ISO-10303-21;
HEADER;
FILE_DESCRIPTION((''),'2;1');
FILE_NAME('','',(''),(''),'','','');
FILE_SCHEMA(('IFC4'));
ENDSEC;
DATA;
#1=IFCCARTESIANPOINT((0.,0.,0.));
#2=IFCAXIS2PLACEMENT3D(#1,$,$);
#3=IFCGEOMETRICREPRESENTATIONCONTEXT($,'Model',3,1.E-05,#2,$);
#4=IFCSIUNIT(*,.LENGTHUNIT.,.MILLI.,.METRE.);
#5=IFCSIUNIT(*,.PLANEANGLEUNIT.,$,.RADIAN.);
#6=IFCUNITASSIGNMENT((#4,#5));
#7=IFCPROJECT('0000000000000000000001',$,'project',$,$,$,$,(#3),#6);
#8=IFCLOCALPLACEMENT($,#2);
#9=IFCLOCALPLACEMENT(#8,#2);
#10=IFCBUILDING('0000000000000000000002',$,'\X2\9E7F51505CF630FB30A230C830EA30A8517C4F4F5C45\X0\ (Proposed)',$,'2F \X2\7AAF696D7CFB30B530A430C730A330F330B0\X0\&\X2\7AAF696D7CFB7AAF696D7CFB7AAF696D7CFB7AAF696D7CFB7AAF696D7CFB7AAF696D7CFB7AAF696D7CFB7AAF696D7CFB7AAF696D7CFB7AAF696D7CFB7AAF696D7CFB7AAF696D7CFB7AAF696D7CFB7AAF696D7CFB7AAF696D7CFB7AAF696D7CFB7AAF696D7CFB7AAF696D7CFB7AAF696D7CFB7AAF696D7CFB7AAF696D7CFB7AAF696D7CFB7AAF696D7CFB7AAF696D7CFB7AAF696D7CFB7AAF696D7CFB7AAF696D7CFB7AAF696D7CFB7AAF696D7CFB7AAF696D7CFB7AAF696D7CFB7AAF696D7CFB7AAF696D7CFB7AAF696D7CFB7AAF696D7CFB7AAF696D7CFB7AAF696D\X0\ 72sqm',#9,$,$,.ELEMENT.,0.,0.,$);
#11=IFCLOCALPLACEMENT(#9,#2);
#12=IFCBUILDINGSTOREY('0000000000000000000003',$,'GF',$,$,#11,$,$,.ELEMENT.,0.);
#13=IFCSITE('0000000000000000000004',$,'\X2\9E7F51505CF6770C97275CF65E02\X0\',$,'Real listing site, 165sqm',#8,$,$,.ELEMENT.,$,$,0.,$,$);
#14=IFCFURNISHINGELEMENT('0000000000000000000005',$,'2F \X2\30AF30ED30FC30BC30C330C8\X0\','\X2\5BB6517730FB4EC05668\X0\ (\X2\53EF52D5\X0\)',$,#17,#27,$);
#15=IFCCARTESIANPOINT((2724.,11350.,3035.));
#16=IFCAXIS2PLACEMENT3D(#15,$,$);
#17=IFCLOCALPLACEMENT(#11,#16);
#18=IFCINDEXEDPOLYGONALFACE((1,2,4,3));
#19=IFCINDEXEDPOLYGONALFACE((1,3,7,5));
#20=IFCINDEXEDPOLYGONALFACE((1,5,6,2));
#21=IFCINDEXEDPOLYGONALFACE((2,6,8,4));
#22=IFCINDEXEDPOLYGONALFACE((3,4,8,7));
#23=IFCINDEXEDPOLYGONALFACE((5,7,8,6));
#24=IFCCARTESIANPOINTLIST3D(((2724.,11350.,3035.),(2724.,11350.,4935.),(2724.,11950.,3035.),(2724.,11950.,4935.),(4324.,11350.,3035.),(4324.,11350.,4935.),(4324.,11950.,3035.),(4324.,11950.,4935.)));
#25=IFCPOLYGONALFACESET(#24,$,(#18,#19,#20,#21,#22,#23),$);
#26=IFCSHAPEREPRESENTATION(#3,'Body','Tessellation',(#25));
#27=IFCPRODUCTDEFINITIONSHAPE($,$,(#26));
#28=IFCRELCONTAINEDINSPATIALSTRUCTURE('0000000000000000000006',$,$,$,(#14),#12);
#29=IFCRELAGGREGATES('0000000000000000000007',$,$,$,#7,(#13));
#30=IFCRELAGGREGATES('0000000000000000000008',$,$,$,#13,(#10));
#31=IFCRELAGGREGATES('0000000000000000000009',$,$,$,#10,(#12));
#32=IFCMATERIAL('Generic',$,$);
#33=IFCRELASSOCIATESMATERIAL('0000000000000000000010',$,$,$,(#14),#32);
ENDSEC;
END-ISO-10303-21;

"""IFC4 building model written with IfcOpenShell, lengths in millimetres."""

from ifc_helpers import new_model, si_unit, frame, frame_2d, origin, place, context, project, spatial, rectangle, extrude, material, element, save


model = new_model("IFC4")

# Units and contexts
model_context = context("Model", 3, precision=1e-05, world=origin())
ifc_project = project(units=[si_unit("LENGTHUNIT", "METRE", prefix="MILLI"), si_unit("PLANEANGLEUNIT", "RADIAN")], contexts=[model_context])

# Site, building, storey
site_placement = place(None, origin())
site = spatial("IfcSite", under=ifc_project, at=site_placement, Name="鹿児島県霧島市", ObjectType="Real listing site, 165sqm", CompositionType="ELEMENT", RefElevation=0.0)
building_placement = place(site_placement, origin())
building = spatial("IfcBuilding", under=site, at=building_placement, Name="鹿児島・アトリエ兼住居 (Proposed)", ObjectType="2F 窯業系サイディング&窯業系窯業系窯業系窯業系窯業系窯業系窯業系窯業系窯業系窯業系窯業系窯業系窯業系窯業系窯業系窯業系窯業系窯業系窯業系窯業系窯業系窯業系窯業系窯業系窯業系窯業系窯業系窯業系窯業系窯業系窯業系窯業系窯業系窯業系窯業系窯業系窯業 72sqm", CompositionType="ELEMENT", ElevationOfRefHeight=0.0, ElevationOfTerrain=0.0)
storey_placement = place(building_placement, origin())
storey = spatial("IfcBuildingStorey", under=building, at=storey_placement, Name="GF", CompositionType="ELEMENT", Elevation=0.0)

# Shared definitions
ifc_material_1 = material(Name="Generic")

# Furnishing element
furnishing_1_placement = place(storey_placement, frame((2724.0, 11350.0, 3035.0)))
element("IfcFurnishingElement", 1, at=furnishing_1_placement, inside=storey, material=ifc_material_1, Name="2F クローゼット", Description="家具・什器 (可動)", context=model_context, shape_type="SweptSolid", body=[
    extrude(rectangle(XDim=1600.0, YDim=600.0, at=frame_2d((800.0, 300.0))), frame((2724.0, 11350.0, 3035.0)), (0.0, 0.0, 1.0), 1900.0),
])

save(model, "model.ifc")
